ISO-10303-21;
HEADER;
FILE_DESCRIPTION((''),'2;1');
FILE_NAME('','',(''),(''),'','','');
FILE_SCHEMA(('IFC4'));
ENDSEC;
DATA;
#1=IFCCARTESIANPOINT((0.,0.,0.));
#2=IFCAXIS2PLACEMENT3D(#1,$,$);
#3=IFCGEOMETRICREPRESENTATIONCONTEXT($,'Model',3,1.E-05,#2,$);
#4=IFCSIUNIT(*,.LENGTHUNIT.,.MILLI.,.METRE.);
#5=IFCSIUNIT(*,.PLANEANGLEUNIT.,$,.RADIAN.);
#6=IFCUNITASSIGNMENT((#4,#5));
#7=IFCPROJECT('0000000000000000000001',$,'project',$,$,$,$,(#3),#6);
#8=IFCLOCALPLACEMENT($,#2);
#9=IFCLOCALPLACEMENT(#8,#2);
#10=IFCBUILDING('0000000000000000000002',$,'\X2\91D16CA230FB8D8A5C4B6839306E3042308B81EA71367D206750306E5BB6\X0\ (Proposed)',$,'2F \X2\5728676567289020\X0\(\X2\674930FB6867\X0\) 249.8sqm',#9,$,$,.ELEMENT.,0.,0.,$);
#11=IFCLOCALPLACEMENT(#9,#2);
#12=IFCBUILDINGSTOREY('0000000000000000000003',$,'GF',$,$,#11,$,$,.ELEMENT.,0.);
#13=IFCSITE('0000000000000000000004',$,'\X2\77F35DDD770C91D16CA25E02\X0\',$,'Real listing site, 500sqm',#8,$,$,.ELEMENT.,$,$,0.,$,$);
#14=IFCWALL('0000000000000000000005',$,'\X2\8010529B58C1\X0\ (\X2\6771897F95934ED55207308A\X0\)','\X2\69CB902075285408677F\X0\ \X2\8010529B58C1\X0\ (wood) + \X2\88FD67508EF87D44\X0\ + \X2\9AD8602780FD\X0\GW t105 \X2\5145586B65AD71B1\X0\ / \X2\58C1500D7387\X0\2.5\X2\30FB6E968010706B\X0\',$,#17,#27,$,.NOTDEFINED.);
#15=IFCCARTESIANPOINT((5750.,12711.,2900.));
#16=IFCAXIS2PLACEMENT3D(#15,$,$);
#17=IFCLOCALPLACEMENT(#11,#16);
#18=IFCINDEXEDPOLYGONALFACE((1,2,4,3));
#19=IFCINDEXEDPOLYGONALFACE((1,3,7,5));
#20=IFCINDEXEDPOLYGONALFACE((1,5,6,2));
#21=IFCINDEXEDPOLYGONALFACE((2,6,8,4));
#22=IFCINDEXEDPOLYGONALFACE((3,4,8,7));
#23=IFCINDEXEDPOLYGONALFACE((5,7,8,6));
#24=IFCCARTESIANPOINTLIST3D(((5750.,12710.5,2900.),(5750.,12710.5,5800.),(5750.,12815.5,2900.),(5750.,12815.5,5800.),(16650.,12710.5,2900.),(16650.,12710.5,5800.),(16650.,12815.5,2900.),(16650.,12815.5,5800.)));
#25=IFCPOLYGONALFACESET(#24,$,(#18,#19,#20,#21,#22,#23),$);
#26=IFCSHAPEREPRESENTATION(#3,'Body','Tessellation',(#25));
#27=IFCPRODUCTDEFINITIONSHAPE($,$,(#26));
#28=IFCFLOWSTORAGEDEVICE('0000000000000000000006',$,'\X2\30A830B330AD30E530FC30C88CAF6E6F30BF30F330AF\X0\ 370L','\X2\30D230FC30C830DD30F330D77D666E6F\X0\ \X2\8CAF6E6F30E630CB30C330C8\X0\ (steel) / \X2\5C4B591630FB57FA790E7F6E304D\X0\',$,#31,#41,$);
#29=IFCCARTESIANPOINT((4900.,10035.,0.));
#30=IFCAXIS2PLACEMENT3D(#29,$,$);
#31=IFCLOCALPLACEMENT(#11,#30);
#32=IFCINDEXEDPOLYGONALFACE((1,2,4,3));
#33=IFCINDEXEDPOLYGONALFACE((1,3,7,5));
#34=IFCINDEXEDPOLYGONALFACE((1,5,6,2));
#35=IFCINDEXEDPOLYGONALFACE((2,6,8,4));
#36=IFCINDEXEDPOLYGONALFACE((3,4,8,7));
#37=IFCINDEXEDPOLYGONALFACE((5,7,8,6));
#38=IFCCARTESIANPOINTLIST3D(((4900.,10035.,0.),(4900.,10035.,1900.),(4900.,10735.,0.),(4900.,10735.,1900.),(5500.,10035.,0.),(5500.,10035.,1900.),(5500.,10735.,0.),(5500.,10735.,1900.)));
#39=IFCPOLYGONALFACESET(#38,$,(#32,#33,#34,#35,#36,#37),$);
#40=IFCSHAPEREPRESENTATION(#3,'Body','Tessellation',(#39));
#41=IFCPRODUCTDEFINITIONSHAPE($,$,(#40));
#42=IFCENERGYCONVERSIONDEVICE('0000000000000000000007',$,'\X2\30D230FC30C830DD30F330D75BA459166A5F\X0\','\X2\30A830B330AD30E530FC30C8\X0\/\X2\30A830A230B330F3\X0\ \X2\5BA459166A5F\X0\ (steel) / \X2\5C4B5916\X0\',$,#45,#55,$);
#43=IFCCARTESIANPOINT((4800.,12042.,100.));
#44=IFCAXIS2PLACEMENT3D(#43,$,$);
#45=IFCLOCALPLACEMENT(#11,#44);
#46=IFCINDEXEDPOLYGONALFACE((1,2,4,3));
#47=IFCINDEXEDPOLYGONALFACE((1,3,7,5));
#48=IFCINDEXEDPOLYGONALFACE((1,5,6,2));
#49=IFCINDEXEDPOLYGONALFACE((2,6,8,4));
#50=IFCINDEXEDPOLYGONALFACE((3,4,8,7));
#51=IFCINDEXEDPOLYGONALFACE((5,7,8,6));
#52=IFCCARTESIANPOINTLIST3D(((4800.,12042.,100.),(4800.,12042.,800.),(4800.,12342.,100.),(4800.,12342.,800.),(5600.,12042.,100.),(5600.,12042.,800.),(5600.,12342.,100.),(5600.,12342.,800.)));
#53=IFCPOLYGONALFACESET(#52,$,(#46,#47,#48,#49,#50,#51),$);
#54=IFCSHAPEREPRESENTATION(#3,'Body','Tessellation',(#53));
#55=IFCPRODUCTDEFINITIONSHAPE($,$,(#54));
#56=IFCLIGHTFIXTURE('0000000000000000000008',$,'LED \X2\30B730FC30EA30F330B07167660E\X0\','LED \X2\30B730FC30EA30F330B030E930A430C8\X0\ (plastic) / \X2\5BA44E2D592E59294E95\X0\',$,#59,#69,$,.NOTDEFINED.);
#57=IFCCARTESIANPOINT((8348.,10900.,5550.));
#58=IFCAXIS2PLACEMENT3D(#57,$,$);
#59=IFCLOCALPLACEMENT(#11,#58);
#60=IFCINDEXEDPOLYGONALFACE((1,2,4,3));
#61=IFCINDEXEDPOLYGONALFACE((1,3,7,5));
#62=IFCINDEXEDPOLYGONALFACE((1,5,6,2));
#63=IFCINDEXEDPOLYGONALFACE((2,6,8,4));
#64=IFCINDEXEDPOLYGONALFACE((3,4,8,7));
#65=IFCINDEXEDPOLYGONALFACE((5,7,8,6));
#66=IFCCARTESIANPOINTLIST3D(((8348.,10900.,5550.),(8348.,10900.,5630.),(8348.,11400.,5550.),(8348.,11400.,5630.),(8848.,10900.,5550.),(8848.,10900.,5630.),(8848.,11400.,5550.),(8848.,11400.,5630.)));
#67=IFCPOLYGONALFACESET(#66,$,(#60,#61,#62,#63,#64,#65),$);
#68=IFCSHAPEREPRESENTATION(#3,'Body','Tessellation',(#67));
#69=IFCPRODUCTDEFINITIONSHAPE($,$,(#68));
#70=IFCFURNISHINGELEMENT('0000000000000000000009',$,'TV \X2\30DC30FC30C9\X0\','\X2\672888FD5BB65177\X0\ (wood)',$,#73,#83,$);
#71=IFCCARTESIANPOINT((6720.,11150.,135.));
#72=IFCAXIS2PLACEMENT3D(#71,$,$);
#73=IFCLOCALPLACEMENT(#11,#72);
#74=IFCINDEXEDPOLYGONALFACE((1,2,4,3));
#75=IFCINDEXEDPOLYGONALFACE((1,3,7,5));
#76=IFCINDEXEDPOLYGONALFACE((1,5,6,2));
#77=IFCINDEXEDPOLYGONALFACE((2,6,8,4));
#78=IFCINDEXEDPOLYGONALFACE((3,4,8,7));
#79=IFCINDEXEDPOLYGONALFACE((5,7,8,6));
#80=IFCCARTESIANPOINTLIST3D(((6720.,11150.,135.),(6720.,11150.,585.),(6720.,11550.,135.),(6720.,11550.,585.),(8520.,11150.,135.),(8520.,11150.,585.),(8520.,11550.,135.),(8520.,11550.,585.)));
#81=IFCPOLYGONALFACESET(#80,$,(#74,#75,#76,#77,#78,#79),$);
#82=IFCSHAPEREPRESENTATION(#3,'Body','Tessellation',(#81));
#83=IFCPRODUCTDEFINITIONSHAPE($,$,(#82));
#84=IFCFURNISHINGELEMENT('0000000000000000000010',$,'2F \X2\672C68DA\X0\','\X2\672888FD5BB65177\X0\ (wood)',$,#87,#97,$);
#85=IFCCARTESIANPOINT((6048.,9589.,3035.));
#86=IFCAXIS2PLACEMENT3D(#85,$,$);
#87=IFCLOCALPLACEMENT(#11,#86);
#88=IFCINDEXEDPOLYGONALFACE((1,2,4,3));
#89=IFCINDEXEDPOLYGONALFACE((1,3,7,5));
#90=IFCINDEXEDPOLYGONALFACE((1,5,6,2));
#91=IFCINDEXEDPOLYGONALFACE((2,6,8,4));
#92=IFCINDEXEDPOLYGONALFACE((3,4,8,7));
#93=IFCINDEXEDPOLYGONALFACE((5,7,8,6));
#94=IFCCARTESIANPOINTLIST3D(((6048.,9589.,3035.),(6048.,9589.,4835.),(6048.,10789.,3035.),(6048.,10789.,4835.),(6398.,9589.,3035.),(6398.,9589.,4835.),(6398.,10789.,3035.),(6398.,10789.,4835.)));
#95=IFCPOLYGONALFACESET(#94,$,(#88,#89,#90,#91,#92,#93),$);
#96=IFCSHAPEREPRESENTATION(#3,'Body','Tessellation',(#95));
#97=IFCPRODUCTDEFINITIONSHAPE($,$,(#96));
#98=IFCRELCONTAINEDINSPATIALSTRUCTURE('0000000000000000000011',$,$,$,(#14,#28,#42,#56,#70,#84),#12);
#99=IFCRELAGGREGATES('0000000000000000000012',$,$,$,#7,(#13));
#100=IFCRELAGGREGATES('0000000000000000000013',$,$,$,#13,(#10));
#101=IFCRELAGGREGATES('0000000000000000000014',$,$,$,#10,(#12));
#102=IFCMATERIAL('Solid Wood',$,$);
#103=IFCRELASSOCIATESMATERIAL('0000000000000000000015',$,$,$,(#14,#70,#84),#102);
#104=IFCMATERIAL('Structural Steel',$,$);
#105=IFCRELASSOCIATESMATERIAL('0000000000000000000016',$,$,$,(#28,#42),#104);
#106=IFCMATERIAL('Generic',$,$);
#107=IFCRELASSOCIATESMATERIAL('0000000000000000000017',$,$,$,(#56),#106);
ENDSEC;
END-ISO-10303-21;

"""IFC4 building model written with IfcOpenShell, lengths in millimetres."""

from ifc_helpers import new_model, si_unit, frame, frame_2d, origin, place, context, project, spatial, rectangle, extrude, material, element, save


model = new_model("IFC4")

# Units and contexts
model_context = context("Model", 3, precision=1e-05, world=origin())
ifc_project = project(units=[si_unit("LENGTHUNIT", "METRE", prefix="MILLI"), si_unit("PLANEANGLEUNIT", "RADIAN")], contexts=[model_context])

# Site, building, storey
site_placement = place(None, origin())
site = spatial("IfcSite", under=ifc_project, at=site_placement, Name="石川県金沢市", ObjectType="Real listing site, 500sqm", CompositionType="ELEMENT", RefElevation=0.0)
building_placement = place(site_placement, origin())
building = spatial("IfcBuilding", under=site, at=building_placement, Name="金沢・越屋根のある自然素材の家 (Proposed)", ObjectType="2F 在来木造(杉・桧) 249.8sqm", CompositionType="ELEMENT", ElevationOfRefHeight=0.0, ElevationOfTerrain=0.0)
storey_placement = place(building_placement, origin())
storey = spatial("IfcBuildingStorey", under=building, at=storey_placement, Name="GF", CompositionType="ELEMENT", Elevation=0.0)

# Shared definitions
ifc_material_1 = material(Name="Solid Wood")

# Wall
wall_1_placement = place(storey_placement, frame((5750.0, 12711.0, 2900.0)))
element("IfcWall", 1, at=wall_1_placement, inside=storey, material=ifc_material_1, Name="耐力壁 (東西間仕切り)", Description="構造用合板 耐力壁 (wood) + 製材軸組 + 高性能GW t105 充填断熱 / 壁倍率2.5・準耐火", PredefinedType="NOTDEFINED", context=model_context, shape_type="SweptSolid", body=[
    extrude(rectangle(XDim=10900.0, YDim=105.0, at=frame_2d((5450.0, 52.0))), frame((5750.0, 12711.0, 2900.0)), (0.0, 0.0, 1.0), 2900.0),
])

# Flow storage device
ifc_material_2 = material(Name="Structural Steel")
flow_storage_device_placement = place(storey_placement, frame((4900.0, 10035.0, 0.0)))
element("IfcFlowStorageDevice", 2, at=flow_storage_device_placement, inside=storey, material=ifc_material_2, Name="エコキュート貯湯タンク 370L", Description="ヒートポンプ給湯 貯湯ユニット (steel) / 屋外・基礎置き", context=model_context, shape_type="SweptSolid", body=[
    extrude(rectangle(XDim=600.0, YDim=700.0, at=frame_2d((300.0, 350.0))), frame((4900.0, 10035.0, 0.0)), (0.0, 0.0, 1.0), 1900.0),
])

# Energy conversion device
energy_conversion_device_placement = place(storey_placement, frame((4800.0, 12042.0, 100.0)))
element("IfcEnergyConversionDevice", 3, at=energy_conversion_device_placement, inside=storey, material=ifc_material_2, Name="ヒートポンプ室外機", Description="エコキュート/エアコン 室外機 (steel) / 屋外", context=model_context, shape_type="SweptSolid", body=[
    extrude(rectangle(XDim=800.0, YDim=300.0, at=frame_2d((400.0, 150.0))), frame((4800.0, 12042.0, 100.0)), (0.0, 0.0, 1.0), 700.0),
])

# Light fixture
ifc_material_3 = material(Name="Generic")
light_fixture_placement = place(storey_placement, frame((8348.0, 10900.0, 5550.0)))
element("IfcLightFixture", 4, at=light_fixture_placement, inside=storey, material=ifc_material_3, Name="LED シーリング照明", Description="LED シーリングライト (plastic) / 室中央天井", PredefinedType="NOTDEFINED", context=model_context, shape_type="SweptSolid", body=[
    extrude(rectangle(XDim=500.0, YDim=500.0, at=frame_2d((250.0, 250.0))), frame((8348.0, 10900.0, 5550.0)), (0.0, 0.0, 1.0), 80.0),
])

# Furnishing elements
furnishing_1_placement = place(storey_placement, frame((6720.0, 11150.0, 135.0)))
element("IfcFurnishingElement", 5, at=furnishing_1_placement, inside=storey, material=ifc_material_1, Name="TV ボード", Description="木製家具 (wood)", context=model_context, shape_type="SweptSolid", body=[
    extrude(rectangle(XDim=1800.0, YDim=400.0, at=frame_2d((900.0, 200.0))), frame((6720.0, 11150.0, 135.0)), (0.0, 0.0, 1.0), 450.0),
])
furnishing_2_placement = place(storey_placement, frame((6048.0, 9589.0, 3035.0)))
element("IfcFurnishingElement", 6, at=furnishing_2_placement, inside=storey, material=ifc_material_1, Name="2F 本棚", Description="木製家具 (wood)", context=model_context, shape_type="SweptSolid", body=[
    extrude(rectangle(XDim=350.0, YDim=1200.0, at=frame_2d((175.0, 600.0))), frame((6048.0, 9589.0, 3035.0)), (0.0, 0.0, 1.0), 1800.0),
])

save(model, "model.ifc")
